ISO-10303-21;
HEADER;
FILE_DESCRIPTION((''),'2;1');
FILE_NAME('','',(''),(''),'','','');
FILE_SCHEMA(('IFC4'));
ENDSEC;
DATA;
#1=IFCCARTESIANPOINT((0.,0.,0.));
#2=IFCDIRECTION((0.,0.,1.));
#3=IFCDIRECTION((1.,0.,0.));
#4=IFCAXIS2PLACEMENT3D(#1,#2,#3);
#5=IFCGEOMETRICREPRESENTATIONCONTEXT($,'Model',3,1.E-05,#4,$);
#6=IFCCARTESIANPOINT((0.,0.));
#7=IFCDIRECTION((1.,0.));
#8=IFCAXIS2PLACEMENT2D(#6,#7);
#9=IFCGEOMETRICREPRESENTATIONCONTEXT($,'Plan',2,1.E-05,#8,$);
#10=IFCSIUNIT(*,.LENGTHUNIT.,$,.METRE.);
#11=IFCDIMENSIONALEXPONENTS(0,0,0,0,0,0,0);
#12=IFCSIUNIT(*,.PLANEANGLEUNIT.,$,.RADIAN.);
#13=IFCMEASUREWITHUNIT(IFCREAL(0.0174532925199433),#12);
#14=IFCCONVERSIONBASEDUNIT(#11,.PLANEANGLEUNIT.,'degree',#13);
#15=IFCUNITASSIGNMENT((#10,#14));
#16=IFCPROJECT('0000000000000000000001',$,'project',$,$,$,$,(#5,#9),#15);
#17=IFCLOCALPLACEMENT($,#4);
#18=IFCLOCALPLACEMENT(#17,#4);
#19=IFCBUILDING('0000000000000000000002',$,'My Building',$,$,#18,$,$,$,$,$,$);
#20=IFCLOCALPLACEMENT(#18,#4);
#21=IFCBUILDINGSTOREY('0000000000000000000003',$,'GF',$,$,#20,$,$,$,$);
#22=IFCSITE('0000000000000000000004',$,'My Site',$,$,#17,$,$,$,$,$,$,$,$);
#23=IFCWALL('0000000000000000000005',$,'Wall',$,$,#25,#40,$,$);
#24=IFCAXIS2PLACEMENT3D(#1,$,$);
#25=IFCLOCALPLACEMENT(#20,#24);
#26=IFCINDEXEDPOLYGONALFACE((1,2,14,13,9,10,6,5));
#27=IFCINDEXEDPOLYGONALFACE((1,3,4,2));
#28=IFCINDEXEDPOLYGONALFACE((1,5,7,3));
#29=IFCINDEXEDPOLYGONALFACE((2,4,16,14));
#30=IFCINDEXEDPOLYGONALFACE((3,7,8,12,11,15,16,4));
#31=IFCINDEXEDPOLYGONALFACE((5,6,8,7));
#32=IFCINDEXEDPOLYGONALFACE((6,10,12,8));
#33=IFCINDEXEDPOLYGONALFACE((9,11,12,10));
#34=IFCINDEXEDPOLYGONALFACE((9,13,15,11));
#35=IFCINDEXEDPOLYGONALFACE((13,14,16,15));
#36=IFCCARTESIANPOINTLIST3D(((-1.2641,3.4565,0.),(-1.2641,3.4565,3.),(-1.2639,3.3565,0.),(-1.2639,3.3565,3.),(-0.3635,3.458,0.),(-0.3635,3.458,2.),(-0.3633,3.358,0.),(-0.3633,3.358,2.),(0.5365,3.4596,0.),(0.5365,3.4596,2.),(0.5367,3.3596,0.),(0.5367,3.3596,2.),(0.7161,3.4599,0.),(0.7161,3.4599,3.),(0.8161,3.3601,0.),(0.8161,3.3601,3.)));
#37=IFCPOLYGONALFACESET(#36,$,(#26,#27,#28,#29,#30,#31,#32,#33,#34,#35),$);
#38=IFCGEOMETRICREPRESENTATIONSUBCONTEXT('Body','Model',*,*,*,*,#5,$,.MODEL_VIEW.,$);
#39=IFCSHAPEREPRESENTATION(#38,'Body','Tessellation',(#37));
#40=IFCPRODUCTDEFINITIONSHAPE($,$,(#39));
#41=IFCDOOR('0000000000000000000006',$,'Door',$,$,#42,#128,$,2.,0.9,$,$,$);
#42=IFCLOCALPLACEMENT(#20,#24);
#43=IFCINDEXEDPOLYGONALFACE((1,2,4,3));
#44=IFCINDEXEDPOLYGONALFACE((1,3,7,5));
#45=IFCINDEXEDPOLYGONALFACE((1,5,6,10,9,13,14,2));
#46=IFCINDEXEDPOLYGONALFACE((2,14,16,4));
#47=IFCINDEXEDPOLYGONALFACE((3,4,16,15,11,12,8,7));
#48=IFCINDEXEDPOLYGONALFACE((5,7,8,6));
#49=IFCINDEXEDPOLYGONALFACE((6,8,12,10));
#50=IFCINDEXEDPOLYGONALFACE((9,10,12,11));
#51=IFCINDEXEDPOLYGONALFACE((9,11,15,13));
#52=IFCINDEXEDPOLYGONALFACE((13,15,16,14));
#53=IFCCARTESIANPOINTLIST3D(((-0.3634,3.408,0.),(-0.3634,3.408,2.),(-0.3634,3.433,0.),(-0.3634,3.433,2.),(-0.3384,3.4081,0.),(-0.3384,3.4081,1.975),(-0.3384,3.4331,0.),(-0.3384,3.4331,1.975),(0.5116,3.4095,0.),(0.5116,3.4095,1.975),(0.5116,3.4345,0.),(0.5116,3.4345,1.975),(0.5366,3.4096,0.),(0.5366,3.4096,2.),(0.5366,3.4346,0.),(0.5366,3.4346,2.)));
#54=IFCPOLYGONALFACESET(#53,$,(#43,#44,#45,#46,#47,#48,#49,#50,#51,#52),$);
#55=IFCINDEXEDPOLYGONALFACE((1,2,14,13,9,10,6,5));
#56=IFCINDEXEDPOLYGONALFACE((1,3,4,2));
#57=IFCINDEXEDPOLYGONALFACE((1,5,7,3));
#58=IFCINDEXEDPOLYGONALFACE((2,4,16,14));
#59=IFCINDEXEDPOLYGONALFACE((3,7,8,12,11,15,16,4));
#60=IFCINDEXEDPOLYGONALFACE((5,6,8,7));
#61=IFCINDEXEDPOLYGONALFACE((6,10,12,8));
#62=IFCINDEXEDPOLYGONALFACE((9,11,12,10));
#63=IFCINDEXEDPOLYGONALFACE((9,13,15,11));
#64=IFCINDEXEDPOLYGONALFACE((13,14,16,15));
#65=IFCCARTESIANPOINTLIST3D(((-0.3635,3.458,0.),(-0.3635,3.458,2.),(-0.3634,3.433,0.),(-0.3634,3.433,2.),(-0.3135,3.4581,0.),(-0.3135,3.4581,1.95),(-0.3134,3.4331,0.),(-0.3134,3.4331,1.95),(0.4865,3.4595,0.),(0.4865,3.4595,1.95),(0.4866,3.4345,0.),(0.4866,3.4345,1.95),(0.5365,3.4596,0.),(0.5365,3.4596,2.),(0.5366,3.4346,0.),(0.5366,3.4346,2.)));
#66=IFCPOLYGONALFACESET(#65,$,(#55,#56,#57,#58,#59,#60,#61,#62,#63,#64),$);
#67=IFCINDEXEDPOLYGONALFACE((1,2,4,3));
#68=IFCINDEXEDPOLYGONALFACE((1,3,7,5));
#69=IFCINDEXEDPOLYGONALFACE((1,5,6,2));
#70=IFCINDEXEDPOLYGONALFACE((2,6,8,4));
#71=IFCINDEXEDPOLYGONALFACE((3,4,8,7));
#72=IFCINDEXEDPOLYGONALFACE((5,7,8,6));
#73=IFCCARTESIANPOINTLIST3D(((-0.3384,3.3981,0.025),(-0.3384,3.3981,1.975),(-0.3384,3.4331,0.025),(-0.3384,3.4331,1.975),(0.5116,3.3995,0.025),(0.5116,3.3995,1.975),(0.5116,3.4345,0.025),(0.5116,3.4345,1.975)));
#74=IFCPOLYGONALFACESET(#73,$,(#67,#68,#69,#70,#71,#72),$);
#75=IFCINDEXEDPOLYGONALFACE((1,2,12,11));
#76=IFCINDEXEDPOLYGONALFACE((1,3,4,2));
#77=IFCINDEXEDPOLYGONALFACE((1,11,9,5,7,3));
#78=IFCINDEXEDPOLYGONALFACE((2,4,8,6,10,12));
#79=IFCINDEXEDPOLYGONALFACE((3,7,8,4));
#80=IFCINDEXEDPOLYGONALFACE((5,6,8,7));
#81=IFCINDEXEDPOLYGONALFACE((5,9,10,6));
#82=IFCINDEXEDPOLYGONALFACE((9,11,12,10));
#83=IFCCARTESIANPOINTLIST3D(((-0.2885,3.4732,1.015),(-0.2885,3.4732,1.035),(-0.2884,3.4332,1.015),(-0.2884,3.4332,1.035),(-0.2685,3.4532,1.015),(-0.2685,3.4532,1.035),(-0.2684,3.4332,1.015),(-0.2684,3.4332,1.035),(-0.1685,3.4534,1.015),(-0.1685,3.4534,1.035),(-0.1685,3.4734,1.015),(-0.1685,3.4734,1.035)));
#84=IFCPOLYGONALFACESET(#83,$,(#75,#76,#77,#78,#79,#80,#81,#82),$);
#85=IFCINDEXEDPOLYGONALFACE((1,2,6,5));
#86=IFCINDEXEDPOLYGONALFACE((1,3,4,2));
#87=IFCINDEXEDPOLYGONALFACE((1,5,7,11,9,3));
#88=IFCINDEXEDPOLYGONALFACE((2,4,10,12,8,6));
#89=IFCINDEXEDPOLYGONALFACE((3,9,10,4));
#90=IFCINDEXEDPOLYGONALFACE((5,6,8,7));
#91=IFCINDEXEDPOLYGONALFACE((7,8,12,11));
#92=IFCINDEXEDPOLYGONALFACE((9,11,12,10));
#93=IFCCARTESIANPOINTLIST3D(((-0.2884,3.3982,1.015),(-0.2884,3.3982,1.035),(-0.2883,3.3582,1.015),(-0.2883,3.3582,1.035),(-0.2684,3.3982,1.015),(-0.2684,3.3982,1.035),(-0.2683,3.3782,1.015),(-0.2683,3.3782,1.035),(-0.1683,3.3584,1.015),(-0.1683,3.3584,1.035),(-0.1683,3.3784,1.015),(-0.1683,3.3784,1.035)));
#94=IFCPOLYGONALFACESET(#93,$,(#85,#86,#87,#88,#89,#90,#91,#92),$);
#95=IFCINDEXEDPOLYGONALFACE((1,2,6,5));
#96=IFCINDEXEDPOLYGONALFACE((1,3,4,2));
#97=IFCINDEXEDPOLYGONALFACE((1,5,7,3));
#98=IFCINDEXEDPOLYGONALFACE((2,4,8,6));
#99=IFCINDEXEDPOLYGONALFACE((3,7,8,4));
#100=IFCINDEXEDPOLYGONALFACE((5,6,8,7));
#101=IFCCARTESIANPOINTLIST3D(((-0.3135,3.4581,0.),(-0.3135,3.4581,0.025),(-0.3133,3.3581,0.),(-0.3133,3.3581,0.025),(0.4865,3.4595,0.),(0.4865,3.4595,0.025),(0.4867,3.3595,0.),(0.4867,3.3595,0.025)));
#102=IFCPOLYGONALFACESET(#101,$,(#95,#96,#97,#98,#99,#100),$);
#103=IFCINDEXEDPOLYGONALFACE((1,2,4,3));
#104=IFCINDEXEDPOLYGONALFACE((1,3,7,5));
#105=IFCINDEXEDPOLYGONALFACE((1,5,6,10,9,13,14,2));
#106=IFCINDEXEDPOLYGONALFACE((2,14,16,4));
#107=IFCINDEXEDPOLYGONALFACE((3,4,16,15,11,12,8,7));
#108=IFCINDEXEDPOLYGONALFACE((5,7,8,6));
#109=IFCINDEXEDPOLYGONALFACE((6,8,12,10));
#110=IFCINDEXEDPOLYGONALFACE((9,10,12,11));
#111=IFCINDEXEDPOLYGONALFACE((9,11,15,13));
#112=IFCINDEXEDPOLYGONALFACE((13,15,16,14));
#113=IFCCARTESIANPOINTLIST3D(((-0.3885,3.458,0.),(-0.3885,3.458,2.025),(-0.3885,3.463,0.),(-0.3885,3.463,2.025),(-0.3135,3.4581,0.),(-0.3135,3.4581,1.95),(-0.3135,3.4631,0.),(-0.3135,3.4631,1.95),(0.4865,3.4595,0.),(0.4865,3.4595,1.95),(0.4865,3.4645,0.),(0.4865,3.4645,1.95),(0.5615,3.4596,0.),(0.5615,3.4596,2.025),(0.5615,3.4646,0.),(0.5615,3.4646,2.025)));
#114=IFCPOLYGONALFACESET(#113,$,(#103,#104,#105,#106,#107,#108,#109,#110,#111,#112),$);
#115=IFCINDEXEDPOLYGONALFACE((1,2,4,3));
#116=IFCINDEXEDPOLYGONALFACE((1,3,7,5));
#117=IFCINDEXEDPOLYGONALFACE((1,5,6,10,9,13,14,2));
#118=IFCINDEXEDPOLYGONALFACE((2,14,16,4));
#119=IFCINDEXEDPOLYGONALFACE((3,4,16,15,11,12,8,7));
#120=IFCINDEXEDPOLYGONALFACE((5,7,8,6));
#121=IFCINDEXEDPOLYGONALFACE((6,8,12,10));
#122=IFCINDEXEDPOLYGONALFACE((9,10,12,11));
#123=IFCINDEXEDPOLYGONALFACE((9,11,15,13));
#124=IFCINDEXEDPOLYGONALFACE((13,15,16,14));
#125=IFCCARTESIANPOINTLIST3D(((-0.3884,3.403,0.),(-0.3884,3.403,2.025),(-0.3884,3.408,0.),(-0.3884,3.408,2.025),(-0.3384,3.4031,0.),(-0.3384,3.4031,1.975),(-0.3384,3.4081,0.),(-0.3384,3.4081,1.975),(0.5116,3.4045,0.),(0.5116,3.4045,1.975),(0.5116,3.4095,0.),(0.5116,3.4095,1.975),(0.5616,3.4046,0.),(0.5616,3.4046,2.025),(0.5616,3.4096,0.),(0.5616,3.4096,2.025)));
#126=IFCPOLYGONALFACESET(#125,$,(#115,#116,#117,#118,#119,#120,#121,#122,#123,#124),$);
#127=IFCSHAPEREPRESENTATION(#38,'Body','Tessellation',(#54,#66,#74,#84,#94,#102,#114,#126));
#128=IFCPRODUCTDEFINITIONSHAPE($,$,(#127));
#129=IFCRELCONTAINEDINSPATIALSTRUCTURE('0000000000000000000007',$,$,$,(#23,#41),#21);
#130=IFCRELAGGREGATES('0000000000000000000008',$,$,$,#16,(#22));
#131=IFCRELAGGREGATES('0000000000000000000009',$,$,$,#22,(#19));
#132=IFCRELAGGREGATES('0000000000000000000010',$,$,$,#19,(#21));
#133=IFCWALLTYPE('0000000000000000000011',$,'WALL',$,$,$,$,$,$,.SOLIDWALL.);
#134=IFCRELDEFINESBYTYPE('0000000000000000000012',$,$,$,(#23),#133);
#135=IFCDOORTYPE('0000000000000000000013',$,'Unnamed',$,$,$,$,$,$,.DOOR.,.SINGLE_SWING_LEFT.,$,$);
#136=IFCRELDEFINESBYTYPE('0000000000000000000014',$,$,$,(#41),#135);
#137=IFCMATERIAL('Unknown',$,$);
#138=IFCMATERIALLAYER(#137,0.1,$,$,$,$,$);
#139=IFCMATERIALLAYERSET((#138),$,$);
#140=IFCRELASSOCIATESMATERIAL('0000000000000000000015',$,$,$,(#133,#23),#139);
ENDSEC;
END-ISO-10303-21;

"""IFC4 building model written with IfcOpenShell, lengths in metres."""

from ifc_helpers import new_model, entity, si_unit, converted_unit, frame, origin_with_axes, origin_2d_with_axis, place, context, subcontext, project, spatial, line, indexed_curve, outline, extrude, shape, source, transform, mapped, material, layer, layer_set, layer_usage, type_object, type_shapes, element, fill, save


model = new_model("IFC4")

# Units and contexts
model_context = context("Model", 3, precision=1e-05, world=origin_with_axes())
plan_context = context("Plan", 2, precision=1e-05, world=origin_2d_with_axis())
body_context_1 = subcontext(model_context, "Body", "Model", "MODEL_VIEW")
body_context_2 = subcontext(plan_context, "Body", "Plan", "PLAN_VIEW")
ifc_project = project(units=[si_unit("LENGTHUNIT", "METRE"), converted_unit("PLANEANGLEUNIT", "degree", entity("IfcReal", 0.0174532925199433), si_unit("PLANEANGLEUNIT", "RADIAN"), dimensions=[0, 0, 0, 0, 0, 0, 0])], contexts=[model_context, plan_context])

# Site, building, storey
site_placement = place(None, origin_with_axes())
site = spatial("IfcSite", under=ifc_project, at=site_placement, Name="My Site")
building_placement = place(site_placement, origin_with_axes())
building = spatial("IfcBuilding", under=site, at=building_placement, Name="My Building")
storey_placement = place(building_placement, origin_with_axes())
storey = spatial("IfcBuildingStorey", under=building, at=storey_placement, Name="GF")

# Shared definitions
ifc_material = material(Name="Unknown")

# Shared definitions
ifc_layer_1 = layer(ifc_material, 0.1)
ifc_layer_set_1 = layer_set([ifc_layer_1])
wall_type = type_object("IfcWallType", Name="WALL", PredefinedType="SOLIDWALL", material=ifc_layer_set_1)

# Wall, opening, door
ifc_layer_usage_1 = layer_usage(ifc_layer_set_1, "AXIS2", "POSITIVE", 0.0)
wall_1_placement = place(storey_placement, frame((0.7161, 3.4599, 0.0), z_axis=(0.0, 0.0, 1.0), x_axis=(-0.999999, -0.00173, 0.0)))
wall_1 = element("IfcWall", 1, at=wall_1_placement, inside=storey, type_object=wall_type, material=ifc_layer_usage_1, Name="Wall", context=body_context_1, shape_type="SweptSolid", body=[
    extrude(outline(indexed_curve([(0.0, 0.0), (-0.0998, 0.1), (1.9802, 0.1), (1.9802, 0.0)], segments=[line(1, 2, 3, 4, 1)])), origin_with_axes(), (0.0, 0.0, 1.0), 3.0),
])
shared_shape_1 = source(origin_with_axes(), body_context_1, "Body", "SweptSolid", [
    extrude(outline(indexed_curve([(0.0, 0.0), (0.9, 0.0), (0.9, 2.0), (0.0, 2.0)], segments=[line(1, 2, 3, 4, 1)])), frame((0.0, -0.6, 0.0), z_axis=(0.0, -1.0, 0.0), x_axis=(1.0, 0.0, 0.0)), (0.0, 0.0, -1.0), 1.2),
])
opening_1_placement = place(wall_1_placement, frame((0.1796, 0.0, 0.0), z_axis=(0.0, 0.0, 1.0), x_axis=(1.0, 0.0, 0.0)))
opening_1 = element("IfcOpeningElement", 2, at=opening_1_placement, cuts=wall_1, PredefinedType="OPENING", context=body_context_1, shape_type="MappedRepresentation", body=[
    mapped(shared_shape_1, transform((0.0, 0.0, 0.0), x_axis=(1.0, 0.0, 0.0), y_axis=(0.0, 1.0, 0.0), z_axis=(0.0, 0.0, 1.0), scale=1.0)),
])
door_type = type_object("IfcDoorType", Name="Unnamed", OperationType="SINGLE_SWING_LEFT", PredefinedType="DOOR")
shared_shape_2 = source(origin_with_axes(), body_context_1, "Body", "SweptSolid", [
    extrude(outline(indexed_curve([(0.0, 0.0), (0.0, 2.0), (0.9, 2.0), (0.9, 0.0), (0.875, 0.0), (0.875, 1.975), (0.025, 1.975), (0.025, 0.0)], segments=[line(1, 2, 3, 4, 5, 6, 7, 8, 1)])), frame((0.0, 0.025, 0.0), z_axis=(0.0, -1.0, 0.0), x_axis=(1.0, 0.0, 0.0)), (0.0, 0.0, -1.0), 0.025),
    extrude(outline(indexed_curve([(0.0, 0.0), (0.0, 2.0), (0.9, 2.0), (0.9, 0.0), (0.85, 0.0), (0.85, 1.95), (0.05, 1.95), (0.05, 0.0)], segments=[line(1, 2, 3, 4, 5, 6, 7, 8, 1)])), frame((0.0, 0.0, 0.0), z_axis=(0.0, -1.0, 0.0), x_axis=(1.0, 0.0, 0.0)), (0.0, 0.0, -1.0), 0.025),
    extrude(outline(indexed_curve([(0.0, 0.0), (0.85, 0.0), (0.85, 0.035), (0.0, 0.035)], segments=[line(1, 2, 3, 4, 1)])), frame((0.025, 0.025, 0.025), z_axis=(0.0, 0.0, 1.0), x_axis=(1.0, 0.0, 0.0)), (0.0, 0.0, 1.0), 1.95),
    extrude(outline(indexed_curve([(0.0, 0.0), (0.0, -0.04), (-0.12, -0.04), (-0.12, -0.02), (-0.02, -0.02), (-0.02, 0.0)], segments=[line(1, 2, 3, 4, 5, 6, 1)])), frame((0.825, 0.025, 1.015), z_axis=(0.0, 0.0, 1.0), x_axis=(1.0, 0.0, 0.0)), (0.0, 0.0, 1.0), 0.02),
    extrude(outline(indexed_curve([(0.0, 0.0), (0.0, 0.04), (-0.12, 0.04), (-0.12, 0.02), (-0.02, 0.02), (-0.02, 0.0)], segments=[line(1, 2, 3, 4, 5, 6, 1)])), frame((0.825, 0.06, 1.015), z_axis=(0.0, 0.0, 1.0), x_axis=(1.0, 0.0, 0.0)), (0.0, 0.0, 1.0), 0.02),
    extrude(outline(indexed_curve([(0.0, 0.0), (0.8, 0.0), (0.8, 0.1), (0.0, 0.1)], segments=[line(1, 2, 3, 4, 1)])), frame((0.05, 0.0, 0.0), z_axis=(0.0, 0.0, 1.0), x_axis=(1.0, 0.0, 0.0)), (0.0, 0.0, 1.0), 0.025),
    extrude(outline(indexed_curve([(0.0, 0.0), (0.0, 2.025), (0.95, 2.025), (0.95, 0.0), (0.875, 0.0), (0.875, 1.95), (0.075, 1.95), (0.075, 0.0)], segments=[line(1, 2, 3, 4, 5, 6, 7, 8, 1)])), frame((-0.025, -0.005, 0.0), z_axis=(0.0, -1.0, 0.0), x_axis=(1.0, 0.0, 0.0)), (0.0, 0.0, -1.0), 0.005),
    extrude(outline(indexed_curve([(0.0, 0.0), (0.0, 2.025), (0.95, 2.025), (0.95, 0.0), (0.9, 0.0), (0.9, 1.975), (0.05, 1.975), (0.05, 0.0)], segments=[line(1, 2, 3, 4, 5, 6, 7, 8, 1)])), frame((-0.025, 0.05, 0.0), z_axis=(0.0, -1.0, 0.0), x_axis=(1.0, 0.0, 0.0)), (0.0, 0.0, -1.0), 0.005),
])
shared_shape_3 = source(origin_with_axes(), body_context_2, "Body", "Curve2D", [
    entity("IfcIndexedPolyCurve", entity("IfcCartesianPointList2D", [[0.0, 0.0], [0.0, 0.05], [0.025, 0.05], [0.025, 0.025], [0.05, 0.025], [0.05, 0.0]]), [entity("IfcLineIndex", [1, 2, 3, 4, 5, 6, 1])]),
    entity("IfcIndexedPolyCurve", entity("IfcCartesianPointList2D", [[0.9, 0.0], [0.9, 0.05], [0.875, 0.05], [0.875, 0.025], [0.85, 0.025], [0.85, 0.0]]), [entity("IfcLineIndex", [1, 2, 3, 4, 5, 6, 1])]),
    entity("IfcTrimmedCurve", entity("IfcEllipse", entity("IfcAxis2Placement2D", entity("IfcCartesianPoint", [0.06, 0.05]), entity("IfcDirection", [1.0, 0.0])), 0.815, 0.85), [entity("IfcCartesianPoint", [0.875, 0.05])], [entity("IfcCartesianPoint", [0.06, 0.9])], True, "CARTESIAN"),
    entity("IfcIndexedPolyCurve", entity("IfcCartesianPointList2D", [[0.025, 0.05], [0.06, 0.05], [0.06, 0.9], [0.025, 0.9]]), [entity("IfcLineIndex", [1, 2, 3, 4, 1])]),
])
type_shapes(door_type, [shared_shape_2, shared_shape_3])
door_placement = place(opening_1_placement, frame((0.0, 0.0, 0.0), z_axis=(0.0, 0.0, 1.0), x_axis=(1.0, 0.0, 0.0)))
door = element("IfcDoor", 3, at=door_placement, inside=storey, type_object=door_type, Name="Door", OverallHeight=2.0, OverallWidth=0.9, shapes=[
    shape(body_context_1, "Body", "MappedRepresentation", [mapped(shared_shape_2, transform((0.0, 0.0, 0.0), x_axis=(1.0, 0.0, 0.0), y_axis=(0.0, 1.0, 0.0), z_axis=(0.0, 0.0, 1.0), scale=1.0))]),
    shape(body_context_2, "Body", "MappedRepresentation", [mapped(shared_shape_3, transform((0.0, 0.0, 0.0), x_axis=(1.0, 0.0, 0.0), y_axis=(0.0, 1.0, 0.0), z_axis=(0.0, 0.0, 1.0), scale=1.0))]),
])
fill(opening_1, door)

save(model, "model.ifc")
